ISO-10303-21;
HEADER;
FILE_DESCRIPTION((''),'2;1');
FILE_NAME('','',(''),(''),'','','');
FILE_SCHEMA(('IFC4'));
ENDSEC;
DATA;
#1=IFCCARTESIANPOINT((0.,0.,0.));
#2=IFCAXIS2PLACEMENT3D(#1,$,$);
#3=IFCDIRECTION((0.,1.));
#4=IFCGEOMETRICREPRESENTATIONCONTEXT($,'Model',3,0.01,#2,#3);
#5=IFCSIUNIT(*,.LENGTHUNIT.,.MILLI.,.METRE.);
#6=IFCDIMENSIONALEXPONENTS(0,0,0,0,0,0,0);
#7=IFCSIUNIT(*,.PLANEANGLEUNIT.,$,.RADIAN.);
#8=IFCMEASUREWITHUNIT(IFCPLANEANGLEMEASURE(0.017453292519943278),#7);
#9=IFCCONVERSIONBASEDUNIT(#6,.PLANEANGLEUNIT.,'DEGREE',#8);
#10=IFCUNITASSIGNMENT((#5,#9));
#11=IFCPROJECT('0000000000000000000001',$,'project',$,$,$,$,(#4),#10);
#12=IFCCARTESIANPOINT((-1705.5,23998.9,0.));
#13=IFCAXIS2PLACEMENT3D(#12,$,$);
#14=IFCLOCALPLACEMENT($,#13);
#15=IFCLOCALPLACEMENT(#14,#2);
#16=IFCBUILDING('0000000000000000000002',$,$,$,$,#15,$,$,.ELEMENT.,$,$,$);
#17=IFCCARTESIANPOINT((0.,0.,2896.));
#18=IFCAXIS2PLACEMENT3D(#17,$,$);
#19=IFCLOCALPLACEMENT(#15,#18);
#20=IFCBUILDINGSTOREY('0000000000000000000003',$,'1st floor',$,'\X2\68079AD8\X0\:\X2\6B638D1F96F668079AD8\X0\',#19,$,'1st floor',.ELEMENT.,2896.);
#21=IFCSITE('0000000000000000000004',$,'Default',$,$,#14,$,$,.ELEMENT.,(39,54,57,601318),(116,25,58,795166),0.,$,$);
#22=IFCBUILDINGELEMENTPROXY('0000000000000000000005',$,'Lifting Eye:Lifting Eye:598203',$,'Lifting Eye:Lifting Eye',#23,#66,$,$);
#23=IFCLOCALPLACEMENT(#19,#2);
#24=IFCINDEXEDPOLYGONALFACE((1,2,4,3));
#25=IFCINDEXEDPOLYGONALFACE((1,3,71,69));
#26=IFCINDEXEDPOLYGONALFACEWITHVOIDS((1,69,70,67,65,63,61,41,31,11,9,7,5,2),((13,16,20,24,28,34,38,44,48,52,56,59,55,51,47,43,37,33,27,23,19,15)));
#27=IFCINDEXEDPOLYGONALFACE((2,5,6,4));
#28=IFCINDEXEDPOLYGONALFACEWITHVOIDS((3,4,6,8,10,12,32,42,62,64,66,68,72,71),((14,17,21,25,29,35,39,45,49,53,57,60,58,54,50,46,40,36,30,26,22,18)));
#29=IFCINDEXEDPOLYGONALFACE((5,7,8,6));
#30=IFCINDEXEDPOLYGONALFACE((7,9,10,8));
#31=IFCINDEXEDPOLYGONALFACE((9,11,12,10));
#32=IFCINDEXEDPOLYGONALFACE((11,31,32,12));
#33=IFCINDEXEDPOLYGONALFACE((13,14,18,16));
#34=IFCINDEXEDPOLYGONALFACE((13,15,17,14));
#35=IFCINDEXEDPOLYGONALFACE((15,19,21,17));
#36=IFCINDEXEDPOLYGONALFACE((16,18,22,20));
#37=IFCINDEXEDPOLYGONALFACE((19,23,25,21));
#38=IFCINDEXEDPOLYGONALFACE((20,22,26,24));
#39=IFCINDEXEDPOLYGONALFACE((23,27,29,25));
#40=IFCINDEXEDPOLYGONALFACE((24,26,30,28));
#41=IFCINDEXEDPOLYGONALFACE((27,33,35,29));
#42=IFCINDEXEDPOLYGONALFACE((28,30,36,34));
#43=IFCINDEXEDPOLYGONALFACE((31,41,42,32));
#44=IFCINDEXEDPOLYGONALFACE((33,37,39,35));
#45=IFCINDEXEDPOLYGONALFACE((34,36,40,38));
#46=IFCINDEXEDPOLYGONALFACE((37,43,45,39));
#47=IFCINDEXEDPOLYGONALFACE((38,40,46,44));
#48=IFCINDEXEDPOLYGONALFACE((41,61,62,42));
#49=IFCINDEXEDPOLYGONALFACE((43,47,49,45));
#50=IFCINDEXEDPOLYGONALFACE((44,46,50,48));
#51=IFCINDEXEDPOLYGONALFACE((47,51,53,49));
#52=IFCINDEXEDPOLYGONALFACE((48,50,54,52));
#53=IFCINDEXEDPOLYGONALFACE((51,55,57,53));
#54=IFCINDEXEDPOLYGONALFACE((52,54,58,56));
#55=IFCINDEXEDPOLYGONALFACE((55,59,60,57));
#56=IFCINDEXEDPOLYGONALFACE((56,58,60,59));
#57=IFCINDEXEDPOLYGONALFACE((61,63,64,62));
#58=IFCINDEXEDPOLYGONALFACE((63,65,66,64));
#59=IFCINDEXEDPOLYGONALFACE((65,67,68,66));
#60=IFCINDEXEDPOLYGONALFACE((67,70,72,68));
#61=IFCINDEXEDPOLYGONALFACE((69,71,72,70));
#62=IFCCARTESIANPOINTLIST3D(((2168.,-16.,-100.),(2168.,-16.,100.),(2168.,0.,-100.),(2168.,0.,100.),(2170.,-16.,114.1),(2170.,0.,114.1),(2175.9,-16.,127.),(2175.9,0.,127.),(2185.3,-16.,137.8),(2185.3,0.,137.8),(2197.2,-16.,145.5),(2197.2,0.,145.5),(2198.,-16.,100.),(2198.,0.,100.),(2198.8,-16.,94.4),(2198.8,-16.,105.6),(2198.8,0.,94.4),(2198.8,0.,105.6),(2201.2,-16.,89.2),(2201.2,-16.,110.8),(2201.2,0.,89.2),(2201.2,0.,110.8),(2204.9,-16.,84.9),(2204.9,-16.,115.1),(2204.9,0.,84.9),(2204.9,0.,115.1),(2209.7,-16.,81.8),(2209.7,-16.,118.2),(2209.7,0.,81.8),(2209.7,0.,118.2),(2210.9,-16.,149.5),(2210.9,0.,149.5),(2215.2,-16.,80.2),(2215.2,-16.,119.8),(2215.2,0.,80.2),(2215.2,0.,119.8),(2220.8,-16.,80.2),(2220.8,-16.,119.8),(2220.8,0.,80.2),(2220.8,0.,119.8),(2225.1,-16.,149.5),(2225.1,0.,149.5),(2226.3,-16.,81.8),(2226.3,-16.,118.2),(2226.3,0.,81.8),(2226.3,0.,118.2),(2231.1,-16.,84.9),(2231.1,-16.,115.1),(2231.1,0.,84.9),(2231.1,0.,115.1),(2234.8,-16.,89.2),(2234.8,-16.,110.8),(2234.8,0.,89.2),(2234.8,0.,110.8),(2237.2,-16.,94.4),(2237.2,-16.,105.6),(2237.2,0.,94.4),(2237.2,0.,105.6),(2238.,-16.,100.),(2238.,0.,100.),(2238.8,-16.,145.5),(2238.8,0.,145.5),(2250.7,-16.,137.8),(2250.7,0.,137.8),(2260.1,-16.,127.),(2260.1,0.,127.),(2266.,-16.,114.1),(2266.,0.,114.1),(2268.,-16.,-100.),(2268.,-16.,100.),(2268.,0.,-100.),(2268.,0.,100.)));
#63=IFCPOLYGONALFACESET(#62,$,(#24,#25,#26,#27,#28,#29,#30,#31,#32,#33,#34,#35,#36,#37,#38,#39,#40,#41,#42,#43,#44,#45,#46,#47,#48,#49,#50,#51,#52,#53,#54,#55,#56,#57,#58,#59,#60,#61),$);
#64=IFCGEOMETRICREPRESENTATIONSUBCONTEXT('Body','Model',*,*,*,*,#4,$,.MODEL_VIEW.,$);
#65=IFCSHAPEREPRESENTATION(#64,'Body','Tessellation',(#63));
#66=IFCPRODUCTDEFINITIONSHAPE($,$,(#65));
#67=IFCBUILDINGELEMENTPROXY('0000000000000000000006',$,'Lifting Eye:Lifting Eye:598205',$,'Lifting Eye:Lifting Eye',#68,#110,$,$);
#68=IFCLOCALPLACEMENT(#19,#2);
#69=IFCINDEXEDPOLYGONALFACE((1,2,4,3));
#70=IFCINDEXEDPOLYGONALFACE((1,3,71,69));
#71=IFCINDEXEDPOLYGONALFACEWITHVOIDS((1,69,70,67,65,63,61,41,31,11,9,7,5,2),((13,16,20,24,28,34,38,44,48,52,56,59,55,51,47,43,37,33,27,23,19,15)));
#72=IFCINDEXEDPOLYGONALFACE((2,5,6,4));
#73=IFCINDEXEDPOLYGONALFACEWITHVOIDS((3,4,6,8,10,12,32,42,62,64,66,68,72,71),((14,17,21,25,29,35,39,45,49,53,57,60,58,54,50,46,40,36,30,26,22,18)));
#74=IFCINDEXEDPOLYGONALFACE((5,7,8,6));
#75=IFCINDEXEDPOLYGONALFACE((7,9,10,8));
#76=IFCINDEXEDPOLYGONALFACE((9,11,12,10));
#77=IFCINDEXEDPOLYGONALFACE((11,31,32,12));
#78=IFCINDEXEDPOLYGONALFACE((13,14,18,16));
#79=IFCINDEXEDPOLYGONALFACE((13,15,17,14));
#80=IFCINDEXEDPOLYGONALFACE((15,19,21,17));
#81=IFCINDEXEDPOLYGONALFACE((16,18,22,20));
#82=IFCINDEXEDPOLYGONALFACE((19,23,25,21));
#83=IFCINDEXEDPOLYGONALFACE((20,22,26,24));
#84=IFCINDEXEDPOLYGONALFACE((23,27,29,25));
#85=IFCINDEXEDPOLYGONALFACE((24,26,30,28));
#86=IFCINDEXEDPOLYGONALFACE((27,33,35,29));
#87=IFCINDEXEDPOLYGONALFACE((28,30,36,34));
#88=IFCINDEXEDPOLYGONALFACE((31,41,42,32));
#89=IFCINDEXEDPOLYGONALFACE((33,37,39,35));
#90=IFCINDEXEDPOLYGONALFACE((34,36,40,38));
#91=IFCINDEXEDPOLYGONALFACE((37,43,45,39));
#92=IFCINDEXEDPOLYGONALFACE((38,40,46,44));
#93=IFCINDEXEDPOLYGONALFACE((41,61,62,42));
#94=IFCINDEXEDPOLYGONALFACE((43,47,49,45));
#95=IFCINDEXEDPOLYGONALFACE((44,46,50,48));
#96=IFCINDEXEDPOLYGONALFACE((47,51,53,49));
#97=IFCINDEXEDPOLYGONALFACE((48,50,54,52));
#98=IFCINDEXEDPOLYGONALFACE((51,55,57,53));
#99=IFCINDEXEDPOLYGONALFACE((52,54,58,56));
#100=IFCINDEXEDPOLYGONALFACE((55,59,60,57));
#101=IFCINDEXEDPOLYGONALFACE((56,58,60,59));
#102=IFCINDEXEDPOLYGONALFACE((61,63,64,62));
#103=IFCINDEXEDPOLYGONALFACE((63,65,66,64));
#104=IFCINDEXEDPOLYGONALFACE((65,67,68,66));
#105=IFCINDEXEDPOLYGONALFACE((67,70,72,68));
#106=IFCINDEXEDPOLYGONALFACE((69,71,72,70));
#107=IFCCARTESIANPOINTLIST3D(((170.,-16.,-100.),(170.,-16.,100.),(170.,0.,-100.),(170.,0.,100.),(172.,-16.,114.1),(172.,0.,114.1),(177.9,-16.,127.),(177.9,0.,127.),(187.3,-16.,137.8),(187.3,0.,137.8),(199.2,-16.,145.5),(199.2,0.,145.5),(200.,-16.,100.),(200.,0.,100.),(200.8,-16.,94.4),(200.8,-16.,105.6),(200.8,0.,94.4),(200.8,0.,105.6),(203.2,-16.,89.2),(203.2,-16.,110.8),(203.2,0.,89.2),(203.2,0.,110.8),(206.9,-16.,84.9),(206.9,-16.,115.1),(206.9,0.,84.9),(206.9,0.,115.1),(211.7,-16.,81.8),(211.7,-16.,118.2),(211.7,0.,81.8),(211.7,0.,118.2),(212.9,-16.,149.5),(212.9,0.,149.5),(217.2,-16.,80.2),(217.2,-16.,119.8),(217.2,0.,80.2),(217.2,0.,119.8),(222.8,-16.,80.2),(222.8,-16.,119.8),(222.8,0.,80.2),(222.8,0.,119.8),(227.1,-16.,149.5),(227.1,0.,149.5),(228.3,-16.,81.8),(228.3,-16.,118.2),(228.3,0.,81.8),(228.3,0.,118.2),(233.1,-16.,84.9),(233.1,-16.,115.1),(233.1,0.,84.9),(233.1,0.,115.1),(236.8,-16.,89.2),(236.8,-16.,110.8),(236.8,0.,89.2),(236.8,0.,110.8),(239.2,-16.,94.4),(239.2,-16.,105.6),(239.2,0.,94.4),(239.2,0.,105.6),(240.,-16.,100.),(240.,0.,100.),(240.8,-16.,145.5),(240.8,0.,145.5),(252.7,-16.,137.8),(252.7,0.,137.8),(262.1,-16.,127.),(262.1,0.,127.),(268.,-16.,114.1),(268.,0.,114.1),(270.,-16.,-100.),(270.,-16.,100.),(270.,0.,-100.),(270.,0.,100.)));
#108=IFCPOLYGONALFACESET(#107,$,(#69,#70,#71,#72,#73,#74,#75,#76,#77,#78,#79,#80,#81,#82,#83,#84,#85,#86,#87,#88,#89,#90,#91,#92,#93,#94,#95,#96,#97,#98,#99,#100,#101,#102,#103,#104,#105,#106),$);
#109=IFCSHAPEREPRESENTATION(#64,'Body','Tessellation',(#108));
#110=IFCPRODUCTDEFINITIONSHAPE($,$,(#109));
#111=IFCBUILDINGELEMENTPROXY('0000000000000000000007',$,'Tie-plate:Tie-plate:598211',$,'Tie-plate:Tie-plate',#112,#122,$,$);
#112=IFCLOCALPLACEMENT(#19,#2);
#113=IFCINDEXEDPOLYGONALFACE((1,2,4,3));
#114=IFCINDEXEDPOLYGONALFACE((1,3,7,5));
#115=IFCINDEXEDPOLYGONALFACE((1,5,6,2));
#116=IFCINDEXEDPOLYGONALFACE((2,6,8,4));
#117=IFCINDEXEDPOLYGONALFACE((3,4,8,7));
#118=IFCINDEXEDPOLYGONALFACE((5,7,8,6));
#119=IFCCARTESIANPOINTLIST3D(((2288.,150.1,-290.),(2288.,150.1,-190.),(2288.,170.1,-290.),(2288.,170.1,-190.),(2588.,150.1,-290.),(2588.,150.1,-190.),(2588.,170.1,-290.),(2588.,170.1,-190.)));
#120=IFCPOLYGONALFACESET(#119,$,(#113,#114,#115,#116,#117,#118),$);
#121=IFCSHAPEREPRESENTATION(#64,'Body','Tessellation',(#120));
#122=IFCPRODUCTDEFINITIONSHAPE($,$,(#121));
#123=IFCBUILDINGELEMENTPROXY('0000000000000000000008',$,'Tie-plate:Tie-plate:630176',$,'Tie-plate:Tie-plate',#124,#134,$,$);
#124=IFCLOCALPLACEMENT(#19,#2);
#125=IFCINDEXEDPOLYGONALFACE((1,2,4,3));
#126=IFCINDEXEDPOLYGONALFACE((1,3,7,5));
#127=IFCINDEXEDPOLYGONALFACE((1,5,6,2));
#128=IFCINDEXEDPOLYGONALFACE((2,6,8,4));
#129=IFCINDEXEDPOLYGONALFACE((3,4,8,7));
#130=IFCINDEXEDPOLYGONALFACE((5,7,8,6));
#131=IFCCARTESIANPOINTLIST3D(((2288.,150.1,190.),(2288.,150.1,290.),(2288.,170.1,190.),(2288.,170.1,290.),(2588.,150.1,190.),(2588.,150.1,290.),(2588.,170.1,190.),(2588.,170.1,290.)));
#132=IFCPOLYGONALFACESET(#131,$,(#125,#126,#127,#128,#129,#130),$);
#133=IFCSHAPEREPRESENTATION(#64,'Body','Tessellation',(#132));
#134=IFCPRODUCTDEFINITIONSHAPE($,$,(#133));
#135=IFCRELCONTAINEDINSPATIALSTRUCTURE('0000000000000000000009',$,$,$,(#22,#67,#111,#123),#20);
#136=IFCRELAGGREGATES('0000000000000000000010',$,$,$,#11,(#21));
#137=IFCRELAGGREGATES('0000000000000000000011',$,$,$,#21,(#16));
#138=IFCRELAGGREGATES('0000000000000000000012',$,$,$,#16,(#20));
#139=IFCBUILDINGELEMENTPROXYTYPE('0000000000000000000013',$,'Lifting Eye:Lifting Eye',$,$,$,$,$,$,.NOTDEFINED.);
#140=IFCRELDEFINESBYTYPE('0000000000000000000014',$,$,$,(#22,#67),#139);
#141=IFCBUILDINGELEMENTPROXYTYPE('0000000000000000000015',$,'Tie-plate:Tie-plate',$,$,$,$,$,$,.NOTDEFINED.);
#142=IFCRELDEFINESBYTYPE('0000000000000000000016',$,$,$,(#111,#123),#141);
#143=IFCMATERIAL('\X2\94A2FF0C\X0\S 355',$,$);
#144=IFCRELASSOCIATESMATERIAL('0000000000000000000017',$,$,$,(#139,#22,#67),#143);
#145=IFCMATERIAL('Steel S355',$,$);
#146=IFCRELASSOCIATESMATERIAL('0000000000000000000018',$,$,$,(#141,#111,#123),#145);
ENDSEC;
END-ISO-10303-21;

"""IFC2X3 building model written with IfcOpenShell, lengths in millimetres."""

from ifc_helpers import new_model, entity, si_unit, converted_unit, direction, frame, frame_2d, origin, place, context, subcontext, project, spatial, polyline, circle_curve, parameter, trimmed, segment, composite_curve, rectangle, outline, extrude, source, transform, mapped, material, type_object, type_shapes, element, save


model = new_model("IFC2X3")

# Units and contexts
model_context = context("Model", 3, precision=0.01, world=origin(), true_north=direction((0.0, 1.0)))
body_context = subcontext(model_context, "Body", "Model", "MODEL_VIEW")
ifc_project = project(units=[si_unit("LENGTHUNIT", "METRE", prefix="MILLI"), converted_unit("PLANEANGLEUNIT", "DEGREE", entity("IfcPlaneAngleMeasure", 0.017453292519943278), si_unit("PLANEANGLEUNIT", "RADIAN"), dimensions=[0, 0, 0, 0, 0, 0, 0])], contexts=[model_context])

# Site, building, storey
site_placement = place(None, frame((-1705.5, 23998.9, 0.0)))
site = spatial("IfcSite", under=ifc_project, at=site_placement, Name="Default", CompositionType="ELEMENT", RefLatitude=(39, 54, 57, 601318), RefLongitude=(116, 25, 58, 795166), RefElevation=0.0)
building_placement = place(site_placement, origin())
building = spatial("IfcBuilding", under=site, at=building_placement, CompositionType="ELEMENT")
storey_placement = place(building_placement, frame((0.0, 0.0, 2896.0)))
storey = spatial("IfcBuildingStorey", under=building, at=storey_placement, Name="1st floor", ObjectType="标高:正负零标高", LongName="1st floor", CompositionType="ELEMENT", Elevation=2896.0)

# Shared definitions
ifc_material_1 = material(Name="Steel S355")

# Building element proxies
ifc_material_2 = material(Name="钢，S 355")
building_element_proxy_type_1 = type_object("IfcBuildingElementProxyType", Name="Lifting Eye:Lifting Eye", PredefinedType="NOTDEFINED", material=ifc_material_2)
shared_shape_1 = source(origin(), body_context, "Body", "SweptSolid", [
    extrude(outline(composite_curve([segment(polyline([(-100.0, -50.0), (100.0, -50.0)]), True, "CONTINUOUS"), segment(polyline([(100.0, -50.0), (100.0, 50.0)]), True, "CONTINUOUS"), segment(polyline([(100.0, 50.0), (-100.0, 50.0)]), True, "CONTINUOUS"), segment(trimmed(circle_curve(frame_2d((-100.0, 0.0), x_axis=(0.0, -1.0)), 50.0), [parameter(180.0)], [parameter(0.0)], True, "PARAMETER"), True, "CONTINUOUS")], self_intersect=False), holes=[composite_curve([segment(trimmed(circle_curve(frame_2d((-100.0, 0.0), x_axis=(0.0, -1.0)), 20.0), [parameter(180.0)], [parameter(360.0)], True, "PARAMETER"), False, "CONTINUOUS"), segment(trimmed(circle_curve(frame_2d((-100.0, 0.0), x_axis=(0.0, -1.0)), 20.0), [parameter(0.0)], [parameter(180.0)], True, "PARAMETER"), False, "CONTINUOUS")], self_intersect=False)]), frame((0.0, 17.0, -17.0), z_axis=(0.0, 1.0, 0.0), x_axis=(0.0, 0.0, -1.0)), (0.0, 0.0, 1.0), 16.0),
])
type_shapes(building_element_proxy_type_1, [shared_shape_1])
for number, where, name in (
    (1, (2218.0, -33.0, 17.0), "Lifting Eye:Lifting Eye:598203"),
    (2, (220.0, -33.0, 17.0), "Lifting Eye:Lifting Eye:598205"),
):
    element("IfcBuildingElementProxy", number, at=place(storey_placement, frame(where)), inside=storey, type_object=building_element_proxy_type_1, material=ifc_material_2, Name=name, ObjectType="Lifting Eye:Lifting Eye", context=body_context, shape_type="MappedRepresentation", body=[
        mapped(shared_shape_1, transform((0.0, 0.0, 0.0), scale=1.0)),
    ])
building_element_proxy_type_2 = type_object("IfcBuildingElementProxyType", Name="Tie-plate:Tie-plate", PredefinedType="NOTDEFINED", material=ifc_material_1)
shared_shape_2 = source(origin(), body_context, "Body", "SweptSolid", [
    extrude(rectangle(XDim=20.0, YDim=300.0, at=frame_2d((0.0, 0.0), x_axis=(1.0, 0.0))), frame((150.0, 10.0, 0.0), z_axis=(0.0, 0.0, 1.0), x_axis=(0.0, 1.0, 0.0)), (0.0, 0.0, 1.0), 100.0),
])
type_shapes(building_element_proxy_type_2, [shared_shape_2])
for number, where, name in (
    (3, (2288.0, 150.1, -290.0), "Tie-plate:Tie-plate:598211"),
    (4, (2288.0, 150.1, 190.0), "Tie-plate:Tie-plate:630176"),
):
    element("IfcBuildingElementProxy", number, at=place(storey_placement, frame(where)), inside=storey, type_object=building_element_proxy_type_2, material=ifc_material_1, Name=name, ObjectType="Tie-plate:Tie-plate", context=body_context, shape_type="MappedRepresentation", body=[
        mapped(shared_shape_2, transform((0.0, 0.0, 0.0), scale=1.0)),
    ])

save(model, "model.ifc")
